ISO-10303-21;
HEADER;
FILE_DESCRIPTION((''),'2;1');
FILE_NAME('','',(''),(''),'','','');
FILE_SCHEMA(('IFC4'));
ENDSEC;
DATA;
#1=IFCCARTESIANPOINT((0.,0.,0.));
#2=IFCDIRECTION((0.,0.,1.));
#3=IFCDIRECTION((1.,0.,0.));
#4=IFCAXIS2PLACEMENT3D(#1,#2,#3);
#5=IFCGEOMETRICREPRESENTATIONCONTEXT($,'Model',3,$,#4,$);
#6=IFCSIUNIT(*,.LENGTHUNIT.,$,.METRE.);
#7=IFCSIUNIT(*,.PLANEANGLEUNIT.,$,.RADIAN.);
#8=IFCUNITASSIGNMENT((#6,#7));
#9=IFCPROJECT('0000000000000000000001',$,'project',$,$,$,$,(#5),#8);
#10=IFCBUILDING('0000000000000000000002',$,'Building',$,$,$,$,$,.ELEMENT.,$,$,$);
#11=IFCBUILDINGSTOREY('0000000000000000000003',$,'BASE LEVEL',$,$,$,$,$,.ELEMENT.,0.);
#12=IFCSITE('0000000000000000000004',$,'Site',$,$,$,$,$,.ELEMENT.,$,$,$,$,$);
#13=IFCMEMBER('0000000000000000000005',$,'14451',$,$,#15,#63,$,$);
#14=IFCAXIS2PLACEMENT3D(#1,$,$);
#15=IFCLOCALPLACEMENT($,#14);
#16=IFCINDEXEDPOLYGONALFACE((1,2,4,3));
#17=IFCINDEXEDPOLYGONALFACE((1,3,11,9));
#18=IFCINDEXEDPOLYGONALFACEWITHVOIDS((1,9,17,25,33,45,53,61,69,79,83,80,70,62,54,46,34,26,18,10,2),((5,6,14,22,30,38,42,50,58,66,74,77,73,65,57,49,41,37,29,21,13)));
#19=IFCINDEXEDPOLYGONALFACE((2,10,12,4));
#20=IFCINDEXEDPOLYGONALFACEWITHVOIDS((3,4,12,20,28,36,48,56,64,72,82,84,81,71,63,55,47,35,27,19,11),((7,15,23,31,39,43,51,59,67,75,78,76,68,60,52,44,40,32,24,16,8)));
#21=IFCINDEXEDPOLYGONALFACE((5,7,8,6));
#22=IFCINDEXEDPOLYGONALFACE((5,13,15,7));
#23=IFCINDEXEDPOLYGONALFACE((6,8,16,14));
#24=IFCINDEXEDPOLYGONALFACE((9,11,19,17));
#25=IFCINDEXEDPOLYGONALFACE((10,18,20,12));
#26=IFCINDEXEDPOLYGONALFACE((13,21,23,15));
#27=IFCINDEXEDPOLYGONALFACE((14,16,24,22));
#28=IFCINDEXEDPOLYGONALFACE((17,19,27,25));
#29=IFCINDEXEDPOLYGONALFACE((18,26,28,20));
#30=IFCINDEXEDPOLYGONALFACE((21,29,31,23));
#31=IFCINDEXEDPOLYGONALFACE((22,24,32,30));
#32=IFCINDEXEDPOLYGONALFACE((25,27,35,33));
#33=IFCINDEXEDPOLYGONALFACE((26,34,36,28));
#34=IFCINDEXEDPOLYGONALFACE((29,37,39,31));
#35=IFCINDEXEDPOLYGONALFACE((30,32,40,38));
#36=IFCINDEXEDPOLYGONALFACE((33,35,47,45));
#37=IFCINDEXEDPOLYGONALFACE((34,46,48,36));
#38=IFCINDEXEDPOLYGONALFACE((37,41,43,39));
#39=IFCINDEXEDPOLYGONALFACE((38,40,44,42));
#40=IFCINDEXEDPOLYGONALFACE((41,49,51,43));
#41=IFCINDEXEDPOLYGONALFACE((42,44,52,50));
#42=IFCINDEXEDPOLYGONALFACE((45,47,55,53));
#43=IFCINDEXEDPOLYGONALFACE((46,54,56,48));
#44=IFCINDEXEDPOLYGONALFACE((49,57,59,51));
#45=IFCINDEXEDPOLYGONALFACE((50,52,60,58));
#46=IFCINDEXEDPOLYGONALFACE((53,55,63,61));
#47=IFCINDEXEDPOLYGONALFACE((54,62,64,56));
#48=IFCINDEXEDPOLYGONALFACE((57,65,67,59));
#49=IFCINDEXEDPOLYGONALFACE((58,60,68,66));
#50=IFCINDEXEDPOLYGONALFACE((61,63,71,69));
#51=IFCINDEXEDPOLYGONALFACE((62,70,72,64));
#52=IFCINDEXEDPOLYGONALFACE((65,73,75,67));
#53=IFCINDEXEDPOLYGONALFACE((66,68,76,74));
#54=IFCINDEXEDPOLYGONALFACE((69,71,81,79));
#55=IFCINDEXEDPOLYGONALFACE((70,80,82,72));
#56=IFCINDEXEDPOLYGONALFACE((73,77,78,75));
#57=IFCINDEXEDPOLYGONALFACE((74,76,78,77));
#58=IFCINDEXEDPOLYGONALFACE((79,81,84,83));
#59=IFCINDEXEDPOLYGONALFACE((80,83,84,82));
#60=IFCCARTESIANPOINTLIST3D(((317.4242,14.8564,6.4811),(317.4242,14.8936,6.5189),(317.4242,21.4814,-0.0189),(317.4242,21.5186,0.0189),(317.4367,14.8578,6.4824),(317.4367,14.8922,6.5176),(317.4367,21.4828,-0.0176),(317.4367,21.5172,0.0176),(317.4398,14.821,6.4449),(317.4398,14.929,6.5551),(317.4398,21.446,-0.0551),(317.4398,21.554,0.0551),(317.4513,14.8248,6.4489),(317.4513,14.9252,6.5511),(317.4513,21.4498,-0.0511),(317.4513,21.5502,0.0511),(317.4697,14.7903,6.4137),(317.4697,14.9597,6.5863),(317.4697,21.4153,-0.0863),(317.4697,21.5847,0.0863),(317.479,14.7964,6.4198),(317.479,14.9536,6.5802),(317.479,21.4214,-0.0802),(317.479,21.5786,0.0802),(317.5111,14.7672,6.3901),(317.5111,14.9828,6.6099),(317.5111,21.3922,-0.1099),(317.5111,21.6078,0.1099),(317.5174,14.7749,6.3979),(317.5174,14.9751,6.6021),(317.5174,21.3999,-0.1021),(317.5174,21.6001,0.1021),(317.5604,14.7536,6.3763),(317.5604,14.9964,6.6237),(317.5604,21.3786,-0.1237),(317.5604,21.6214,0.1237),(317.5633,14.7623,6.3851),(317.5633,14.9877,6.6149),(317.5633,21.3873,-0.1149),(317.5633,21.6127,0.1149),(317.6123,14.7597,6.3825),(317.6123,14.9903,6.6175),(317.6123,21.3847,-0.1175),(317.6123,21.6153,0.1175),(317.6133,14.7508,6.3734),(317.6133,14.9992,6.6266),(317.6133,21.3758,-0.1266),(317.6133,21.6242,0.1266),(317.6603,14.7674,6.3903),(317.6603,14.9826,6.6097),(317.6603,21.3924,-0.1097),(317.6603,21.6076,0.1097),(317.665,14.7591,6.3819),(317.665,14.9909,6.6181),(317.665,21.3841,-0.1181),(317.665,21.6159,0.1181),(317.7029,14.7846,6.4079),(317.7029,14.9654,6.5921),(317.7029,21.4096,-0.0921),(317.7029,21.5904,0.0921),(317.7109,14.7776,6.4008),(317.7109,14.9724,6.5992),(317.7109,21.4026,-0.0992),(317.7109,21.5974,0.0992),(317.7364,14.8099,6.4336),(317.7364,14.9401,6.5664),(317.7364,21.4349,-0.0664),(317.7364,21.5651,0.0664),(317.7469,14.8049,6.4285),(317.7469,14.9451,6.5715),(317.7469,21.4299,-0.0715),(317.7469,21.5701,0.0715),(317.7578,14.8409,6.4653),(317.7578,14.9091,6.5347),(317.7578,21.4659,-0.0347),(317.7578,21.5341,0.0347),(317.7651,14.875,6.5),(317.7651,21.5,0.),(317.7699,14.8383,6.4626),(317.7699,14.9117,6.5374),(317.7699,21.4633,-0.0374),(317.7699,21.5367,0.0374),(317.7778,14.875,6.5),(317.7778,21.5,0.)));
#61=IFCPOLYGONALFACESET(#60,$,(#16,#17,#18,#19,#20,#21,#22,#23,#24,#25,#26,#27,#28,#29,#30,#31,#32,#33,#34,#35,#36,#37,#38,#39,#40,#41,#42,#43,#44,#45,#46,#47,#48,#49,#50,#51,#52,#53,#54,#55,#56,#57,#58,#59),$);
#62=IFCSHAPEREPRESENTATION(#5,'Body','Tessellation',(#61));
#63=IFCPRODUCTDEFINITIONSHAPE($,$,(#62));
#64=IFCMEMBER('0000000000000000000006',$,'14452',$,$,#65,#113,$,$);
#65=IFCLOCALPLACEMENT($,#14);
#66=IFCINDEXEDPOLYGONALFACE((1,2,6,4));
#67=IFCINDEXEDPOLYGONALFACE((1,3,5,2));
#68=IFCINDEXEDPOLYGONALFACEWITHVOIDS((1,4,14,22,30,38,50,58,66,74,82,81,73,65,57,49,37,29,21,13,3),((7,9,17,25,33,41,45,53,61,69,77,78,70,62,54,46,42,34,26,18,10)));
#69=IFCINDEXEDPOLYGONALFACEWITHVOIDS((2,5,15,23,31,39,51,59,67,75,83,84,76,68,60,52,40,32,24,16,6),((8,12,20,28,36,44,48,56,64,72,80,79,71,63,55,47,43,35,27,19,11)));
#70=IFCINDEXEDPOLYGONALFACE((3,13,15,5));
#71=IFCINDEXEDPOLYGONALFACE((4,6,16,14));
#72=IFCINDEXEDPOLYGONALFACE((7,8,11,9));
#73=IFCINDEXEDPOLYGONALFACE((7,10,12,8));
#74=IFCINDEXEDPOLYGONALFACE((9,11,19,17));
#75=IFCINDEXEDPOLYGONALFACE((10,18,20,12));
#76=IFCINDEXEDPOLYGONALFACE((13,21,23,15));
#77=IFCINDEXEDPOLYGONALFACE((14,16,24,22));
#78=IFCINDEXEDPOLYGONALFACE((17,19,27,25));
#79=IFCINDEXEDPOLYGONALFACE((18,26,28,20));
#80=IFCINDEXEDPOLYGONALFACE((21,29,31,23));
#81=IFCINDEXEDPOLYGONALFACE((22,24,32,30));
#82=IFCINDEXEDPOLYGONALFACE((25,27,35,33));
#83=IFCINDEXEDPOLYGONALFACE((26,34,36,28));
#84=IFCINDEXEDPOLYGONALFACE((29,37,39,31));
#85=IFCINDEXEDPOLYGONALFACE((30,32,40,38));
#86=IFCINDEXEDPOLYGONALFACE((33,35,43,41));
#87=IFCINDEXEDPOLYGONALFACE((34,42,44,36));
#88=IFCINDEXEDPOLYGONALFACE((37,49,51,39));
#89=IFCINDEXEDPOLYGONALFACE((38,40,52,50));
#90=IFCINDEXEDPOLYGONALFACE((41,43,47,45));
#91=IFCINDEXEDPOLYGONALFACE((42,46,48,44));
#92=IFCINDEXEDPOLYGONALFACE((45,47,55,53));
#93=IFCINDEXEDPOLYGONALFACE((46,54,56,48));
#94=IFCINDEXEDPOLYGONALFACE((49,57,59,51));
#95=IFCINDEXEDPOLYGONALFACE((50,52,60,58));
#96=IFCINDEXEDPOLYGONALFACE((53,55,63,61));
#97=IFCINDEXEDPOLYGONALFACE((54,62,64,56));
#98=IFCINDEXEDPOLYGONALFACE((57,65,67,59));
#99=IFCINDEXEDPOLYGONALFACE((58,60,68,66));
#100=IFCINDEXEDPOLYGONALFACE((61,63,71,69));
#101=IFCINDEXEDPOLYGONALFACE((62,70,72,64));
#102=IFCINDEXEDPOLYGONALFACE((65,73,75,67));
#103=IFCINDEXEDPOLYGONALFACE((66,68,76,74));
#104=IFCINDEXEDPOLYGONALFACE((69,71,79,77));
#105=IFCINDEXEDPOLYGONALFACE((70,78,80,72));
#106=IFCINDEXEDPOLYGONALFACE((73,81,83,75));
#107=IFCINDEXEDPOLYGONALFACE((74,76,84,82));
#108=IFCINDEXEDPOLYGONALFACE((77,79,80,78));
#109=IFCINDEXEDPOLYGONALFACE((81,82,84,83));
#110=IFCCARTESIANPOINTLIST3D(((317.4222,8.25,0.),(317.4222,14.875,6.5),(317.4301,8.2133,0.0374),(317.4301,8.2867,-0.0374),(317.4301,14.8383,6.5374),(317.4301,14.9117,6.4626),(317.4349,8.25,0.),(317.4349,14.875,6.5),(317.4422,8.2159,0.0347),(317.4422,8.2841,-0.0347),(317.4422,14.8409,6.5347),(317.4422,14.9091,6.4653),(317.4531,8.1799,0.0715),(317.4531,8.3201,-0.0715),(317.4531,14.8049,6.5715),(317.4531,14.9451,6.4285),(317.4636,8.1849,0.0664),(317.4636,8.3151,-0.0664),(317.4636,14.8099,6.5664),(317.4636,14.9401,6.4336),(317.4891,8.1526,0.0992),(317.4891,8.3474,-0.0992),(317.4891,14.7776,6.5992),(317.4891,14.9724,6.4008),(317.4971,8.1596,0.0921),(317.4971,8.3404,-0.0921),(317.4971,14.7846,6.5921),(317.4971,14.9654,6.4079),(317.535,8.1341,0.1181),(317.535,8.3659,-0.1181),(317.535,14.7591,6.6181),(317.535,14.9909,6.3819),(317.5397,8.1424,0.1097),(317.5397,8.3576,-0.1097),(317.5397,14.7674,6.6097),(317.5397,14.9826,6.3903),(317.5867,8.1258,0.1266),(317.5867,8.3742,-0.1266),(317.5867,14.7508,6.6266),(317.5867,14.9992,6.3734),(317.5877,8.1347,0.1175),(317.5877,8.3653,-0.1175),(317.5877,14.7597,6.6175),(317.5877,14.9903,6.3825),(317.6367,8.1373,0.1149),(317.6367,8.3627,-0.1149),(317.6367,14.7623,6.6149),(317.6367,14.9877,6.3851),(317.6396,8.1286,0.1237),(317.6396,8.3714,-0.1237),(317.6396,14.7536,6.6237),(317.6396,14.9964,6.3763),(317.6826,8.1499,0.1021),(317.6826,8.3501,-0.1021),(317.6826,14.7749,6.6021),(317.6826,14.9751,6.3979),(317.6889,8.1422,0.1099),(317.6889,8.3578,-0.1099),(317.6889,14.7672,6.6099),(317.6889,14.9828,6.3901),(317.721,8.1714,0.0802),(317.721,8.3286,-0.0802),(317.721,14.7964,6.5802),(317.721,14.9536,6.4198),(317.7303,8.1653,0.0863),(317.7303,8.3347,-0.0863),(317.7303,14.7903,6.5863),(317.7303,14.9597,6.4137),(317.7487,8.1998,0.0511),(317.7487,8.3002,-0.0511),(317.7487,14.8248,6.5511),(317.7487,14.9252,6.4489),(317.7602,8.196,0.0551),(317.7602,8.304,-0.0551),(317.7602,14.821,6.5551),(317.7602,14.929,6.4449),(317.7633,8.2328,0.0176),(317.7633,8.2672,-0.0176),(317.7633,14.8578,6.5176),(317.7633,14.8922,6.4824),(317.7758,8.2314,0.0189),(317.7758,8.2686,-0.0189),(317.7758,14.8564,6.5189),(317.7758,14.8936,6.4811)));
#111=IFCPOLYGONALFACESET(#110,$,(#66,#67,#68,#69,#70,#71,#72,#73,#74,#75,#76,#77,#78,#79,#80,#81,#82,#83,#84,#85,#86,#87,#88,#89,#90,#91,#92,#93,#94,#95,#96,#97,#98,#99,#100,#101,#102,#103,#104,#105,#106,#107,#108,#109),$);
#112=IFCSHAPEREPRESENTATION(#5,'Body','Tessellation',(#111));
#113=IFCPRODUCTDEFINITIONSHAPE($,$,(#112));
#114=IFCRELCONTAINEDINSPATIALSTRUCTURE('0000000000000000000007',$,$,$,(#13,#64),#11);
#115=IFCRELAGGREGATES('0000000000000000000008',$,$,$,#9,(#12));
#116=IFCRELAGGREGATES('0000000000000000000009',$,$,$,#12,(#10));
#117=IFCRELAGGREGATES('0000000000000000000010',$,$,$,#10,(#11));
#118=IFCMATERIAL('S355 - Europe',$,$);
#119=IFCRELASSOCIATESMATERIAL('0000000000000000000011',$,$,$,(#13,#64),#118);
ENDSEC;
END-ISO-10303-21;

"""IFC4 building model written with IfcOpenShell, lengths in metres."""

from ifc_helpers import new_model, si_unit, frame, origin_with_axes, origin_2d_with_axis, place, context, project, spatial, hollow_circle, extrude, material, material_profile, profile_set, profile_usage, element, save


model = new_model("IFC4")

# Units and contexts
model_context = context("Model", 3, world=origin_with_axes())
ifc_project = project(units=[si_unit("LENGTHUNIT", "METRE"), si_unit("PLANEANGLEUNIT", "RADIAN")], contexts=[model_context])

# Site, building, storey
site = spatial("IfcSite", under=ifc_project, Name="Site", CompositionType="ELEMENT")
building = spatial("IfcBuilding", under=site, Name="Building", CompositionType="ELEMENT")
storey = spatial("IfcBuildingStorey", under=building, Name="BASE LEVEL", CompositionType="ELEMENT", Elevation=0.0)

# Shared definitions
ifc_material = material(Name="S355 - Europe")

# Members
ifc_material_profile_1 = material_profile(ifc_material, hollow_circle(Radius=0.1778, WallThickness=0.0127, at=origin_2d_with_axis()))
ifc_profile_set_1 = profile_set([ifc_material_profile_1])
ifc_profile_usage_1 = profile_usage(ifc_profile_set_1, cardinal=10)
member_1_placement = place(None, frame((317.6, 21.5, 0.0), z_axis=(0.0, -0.713809, 0.700341), x_axis=(1.0, 0.0, 0.0)))
element("IfcMember", 1, at=member_1_placement, inside=storey, material=ifc_profile_usage_1, Name="14451", context=model_context, shape_type="SweptSolid", body=[
    extrude(hollow_circle(Radius=0.1778, WallThickness=0.0127, at=origin_2d_with_axis()), origin_with_axes(), (0.0, 0.0, 1.0), 9.2812),
])
ifc_material_profile_2 = material_profile(ifc_material, hollow_circle(Radius=0.1778, WallThickness=0.0127, at=origin_2d_with_axis()))
ifc_profile_set_2 = profile_set([ifc_material_profile_2])
ifc_profile_usage_2 = profile_usage(ifc_profile_set_2, cardinal=10)
member_2_placement = place(None, frame((317.6, 8.25, 0.0), z_axis=(0.0, 0.713809, 0.700341), x_axis=(-1.0, 0.0, 0.0)))
element("IfcMember", 2, at=member_2_placement, inside=storey, material=ifc_profile_usage_2, Name="14452", context=model_context, shape_type="SweptSolid", body=[
    extrude(hollow_circle(Radius=0.1778, WallThickness=0.0127, at=origin_2d_with_axis()), origin_with_axes(), (0.0, 0.0, 1.0), 9.2812),
])

save(model, "model.ifc")
